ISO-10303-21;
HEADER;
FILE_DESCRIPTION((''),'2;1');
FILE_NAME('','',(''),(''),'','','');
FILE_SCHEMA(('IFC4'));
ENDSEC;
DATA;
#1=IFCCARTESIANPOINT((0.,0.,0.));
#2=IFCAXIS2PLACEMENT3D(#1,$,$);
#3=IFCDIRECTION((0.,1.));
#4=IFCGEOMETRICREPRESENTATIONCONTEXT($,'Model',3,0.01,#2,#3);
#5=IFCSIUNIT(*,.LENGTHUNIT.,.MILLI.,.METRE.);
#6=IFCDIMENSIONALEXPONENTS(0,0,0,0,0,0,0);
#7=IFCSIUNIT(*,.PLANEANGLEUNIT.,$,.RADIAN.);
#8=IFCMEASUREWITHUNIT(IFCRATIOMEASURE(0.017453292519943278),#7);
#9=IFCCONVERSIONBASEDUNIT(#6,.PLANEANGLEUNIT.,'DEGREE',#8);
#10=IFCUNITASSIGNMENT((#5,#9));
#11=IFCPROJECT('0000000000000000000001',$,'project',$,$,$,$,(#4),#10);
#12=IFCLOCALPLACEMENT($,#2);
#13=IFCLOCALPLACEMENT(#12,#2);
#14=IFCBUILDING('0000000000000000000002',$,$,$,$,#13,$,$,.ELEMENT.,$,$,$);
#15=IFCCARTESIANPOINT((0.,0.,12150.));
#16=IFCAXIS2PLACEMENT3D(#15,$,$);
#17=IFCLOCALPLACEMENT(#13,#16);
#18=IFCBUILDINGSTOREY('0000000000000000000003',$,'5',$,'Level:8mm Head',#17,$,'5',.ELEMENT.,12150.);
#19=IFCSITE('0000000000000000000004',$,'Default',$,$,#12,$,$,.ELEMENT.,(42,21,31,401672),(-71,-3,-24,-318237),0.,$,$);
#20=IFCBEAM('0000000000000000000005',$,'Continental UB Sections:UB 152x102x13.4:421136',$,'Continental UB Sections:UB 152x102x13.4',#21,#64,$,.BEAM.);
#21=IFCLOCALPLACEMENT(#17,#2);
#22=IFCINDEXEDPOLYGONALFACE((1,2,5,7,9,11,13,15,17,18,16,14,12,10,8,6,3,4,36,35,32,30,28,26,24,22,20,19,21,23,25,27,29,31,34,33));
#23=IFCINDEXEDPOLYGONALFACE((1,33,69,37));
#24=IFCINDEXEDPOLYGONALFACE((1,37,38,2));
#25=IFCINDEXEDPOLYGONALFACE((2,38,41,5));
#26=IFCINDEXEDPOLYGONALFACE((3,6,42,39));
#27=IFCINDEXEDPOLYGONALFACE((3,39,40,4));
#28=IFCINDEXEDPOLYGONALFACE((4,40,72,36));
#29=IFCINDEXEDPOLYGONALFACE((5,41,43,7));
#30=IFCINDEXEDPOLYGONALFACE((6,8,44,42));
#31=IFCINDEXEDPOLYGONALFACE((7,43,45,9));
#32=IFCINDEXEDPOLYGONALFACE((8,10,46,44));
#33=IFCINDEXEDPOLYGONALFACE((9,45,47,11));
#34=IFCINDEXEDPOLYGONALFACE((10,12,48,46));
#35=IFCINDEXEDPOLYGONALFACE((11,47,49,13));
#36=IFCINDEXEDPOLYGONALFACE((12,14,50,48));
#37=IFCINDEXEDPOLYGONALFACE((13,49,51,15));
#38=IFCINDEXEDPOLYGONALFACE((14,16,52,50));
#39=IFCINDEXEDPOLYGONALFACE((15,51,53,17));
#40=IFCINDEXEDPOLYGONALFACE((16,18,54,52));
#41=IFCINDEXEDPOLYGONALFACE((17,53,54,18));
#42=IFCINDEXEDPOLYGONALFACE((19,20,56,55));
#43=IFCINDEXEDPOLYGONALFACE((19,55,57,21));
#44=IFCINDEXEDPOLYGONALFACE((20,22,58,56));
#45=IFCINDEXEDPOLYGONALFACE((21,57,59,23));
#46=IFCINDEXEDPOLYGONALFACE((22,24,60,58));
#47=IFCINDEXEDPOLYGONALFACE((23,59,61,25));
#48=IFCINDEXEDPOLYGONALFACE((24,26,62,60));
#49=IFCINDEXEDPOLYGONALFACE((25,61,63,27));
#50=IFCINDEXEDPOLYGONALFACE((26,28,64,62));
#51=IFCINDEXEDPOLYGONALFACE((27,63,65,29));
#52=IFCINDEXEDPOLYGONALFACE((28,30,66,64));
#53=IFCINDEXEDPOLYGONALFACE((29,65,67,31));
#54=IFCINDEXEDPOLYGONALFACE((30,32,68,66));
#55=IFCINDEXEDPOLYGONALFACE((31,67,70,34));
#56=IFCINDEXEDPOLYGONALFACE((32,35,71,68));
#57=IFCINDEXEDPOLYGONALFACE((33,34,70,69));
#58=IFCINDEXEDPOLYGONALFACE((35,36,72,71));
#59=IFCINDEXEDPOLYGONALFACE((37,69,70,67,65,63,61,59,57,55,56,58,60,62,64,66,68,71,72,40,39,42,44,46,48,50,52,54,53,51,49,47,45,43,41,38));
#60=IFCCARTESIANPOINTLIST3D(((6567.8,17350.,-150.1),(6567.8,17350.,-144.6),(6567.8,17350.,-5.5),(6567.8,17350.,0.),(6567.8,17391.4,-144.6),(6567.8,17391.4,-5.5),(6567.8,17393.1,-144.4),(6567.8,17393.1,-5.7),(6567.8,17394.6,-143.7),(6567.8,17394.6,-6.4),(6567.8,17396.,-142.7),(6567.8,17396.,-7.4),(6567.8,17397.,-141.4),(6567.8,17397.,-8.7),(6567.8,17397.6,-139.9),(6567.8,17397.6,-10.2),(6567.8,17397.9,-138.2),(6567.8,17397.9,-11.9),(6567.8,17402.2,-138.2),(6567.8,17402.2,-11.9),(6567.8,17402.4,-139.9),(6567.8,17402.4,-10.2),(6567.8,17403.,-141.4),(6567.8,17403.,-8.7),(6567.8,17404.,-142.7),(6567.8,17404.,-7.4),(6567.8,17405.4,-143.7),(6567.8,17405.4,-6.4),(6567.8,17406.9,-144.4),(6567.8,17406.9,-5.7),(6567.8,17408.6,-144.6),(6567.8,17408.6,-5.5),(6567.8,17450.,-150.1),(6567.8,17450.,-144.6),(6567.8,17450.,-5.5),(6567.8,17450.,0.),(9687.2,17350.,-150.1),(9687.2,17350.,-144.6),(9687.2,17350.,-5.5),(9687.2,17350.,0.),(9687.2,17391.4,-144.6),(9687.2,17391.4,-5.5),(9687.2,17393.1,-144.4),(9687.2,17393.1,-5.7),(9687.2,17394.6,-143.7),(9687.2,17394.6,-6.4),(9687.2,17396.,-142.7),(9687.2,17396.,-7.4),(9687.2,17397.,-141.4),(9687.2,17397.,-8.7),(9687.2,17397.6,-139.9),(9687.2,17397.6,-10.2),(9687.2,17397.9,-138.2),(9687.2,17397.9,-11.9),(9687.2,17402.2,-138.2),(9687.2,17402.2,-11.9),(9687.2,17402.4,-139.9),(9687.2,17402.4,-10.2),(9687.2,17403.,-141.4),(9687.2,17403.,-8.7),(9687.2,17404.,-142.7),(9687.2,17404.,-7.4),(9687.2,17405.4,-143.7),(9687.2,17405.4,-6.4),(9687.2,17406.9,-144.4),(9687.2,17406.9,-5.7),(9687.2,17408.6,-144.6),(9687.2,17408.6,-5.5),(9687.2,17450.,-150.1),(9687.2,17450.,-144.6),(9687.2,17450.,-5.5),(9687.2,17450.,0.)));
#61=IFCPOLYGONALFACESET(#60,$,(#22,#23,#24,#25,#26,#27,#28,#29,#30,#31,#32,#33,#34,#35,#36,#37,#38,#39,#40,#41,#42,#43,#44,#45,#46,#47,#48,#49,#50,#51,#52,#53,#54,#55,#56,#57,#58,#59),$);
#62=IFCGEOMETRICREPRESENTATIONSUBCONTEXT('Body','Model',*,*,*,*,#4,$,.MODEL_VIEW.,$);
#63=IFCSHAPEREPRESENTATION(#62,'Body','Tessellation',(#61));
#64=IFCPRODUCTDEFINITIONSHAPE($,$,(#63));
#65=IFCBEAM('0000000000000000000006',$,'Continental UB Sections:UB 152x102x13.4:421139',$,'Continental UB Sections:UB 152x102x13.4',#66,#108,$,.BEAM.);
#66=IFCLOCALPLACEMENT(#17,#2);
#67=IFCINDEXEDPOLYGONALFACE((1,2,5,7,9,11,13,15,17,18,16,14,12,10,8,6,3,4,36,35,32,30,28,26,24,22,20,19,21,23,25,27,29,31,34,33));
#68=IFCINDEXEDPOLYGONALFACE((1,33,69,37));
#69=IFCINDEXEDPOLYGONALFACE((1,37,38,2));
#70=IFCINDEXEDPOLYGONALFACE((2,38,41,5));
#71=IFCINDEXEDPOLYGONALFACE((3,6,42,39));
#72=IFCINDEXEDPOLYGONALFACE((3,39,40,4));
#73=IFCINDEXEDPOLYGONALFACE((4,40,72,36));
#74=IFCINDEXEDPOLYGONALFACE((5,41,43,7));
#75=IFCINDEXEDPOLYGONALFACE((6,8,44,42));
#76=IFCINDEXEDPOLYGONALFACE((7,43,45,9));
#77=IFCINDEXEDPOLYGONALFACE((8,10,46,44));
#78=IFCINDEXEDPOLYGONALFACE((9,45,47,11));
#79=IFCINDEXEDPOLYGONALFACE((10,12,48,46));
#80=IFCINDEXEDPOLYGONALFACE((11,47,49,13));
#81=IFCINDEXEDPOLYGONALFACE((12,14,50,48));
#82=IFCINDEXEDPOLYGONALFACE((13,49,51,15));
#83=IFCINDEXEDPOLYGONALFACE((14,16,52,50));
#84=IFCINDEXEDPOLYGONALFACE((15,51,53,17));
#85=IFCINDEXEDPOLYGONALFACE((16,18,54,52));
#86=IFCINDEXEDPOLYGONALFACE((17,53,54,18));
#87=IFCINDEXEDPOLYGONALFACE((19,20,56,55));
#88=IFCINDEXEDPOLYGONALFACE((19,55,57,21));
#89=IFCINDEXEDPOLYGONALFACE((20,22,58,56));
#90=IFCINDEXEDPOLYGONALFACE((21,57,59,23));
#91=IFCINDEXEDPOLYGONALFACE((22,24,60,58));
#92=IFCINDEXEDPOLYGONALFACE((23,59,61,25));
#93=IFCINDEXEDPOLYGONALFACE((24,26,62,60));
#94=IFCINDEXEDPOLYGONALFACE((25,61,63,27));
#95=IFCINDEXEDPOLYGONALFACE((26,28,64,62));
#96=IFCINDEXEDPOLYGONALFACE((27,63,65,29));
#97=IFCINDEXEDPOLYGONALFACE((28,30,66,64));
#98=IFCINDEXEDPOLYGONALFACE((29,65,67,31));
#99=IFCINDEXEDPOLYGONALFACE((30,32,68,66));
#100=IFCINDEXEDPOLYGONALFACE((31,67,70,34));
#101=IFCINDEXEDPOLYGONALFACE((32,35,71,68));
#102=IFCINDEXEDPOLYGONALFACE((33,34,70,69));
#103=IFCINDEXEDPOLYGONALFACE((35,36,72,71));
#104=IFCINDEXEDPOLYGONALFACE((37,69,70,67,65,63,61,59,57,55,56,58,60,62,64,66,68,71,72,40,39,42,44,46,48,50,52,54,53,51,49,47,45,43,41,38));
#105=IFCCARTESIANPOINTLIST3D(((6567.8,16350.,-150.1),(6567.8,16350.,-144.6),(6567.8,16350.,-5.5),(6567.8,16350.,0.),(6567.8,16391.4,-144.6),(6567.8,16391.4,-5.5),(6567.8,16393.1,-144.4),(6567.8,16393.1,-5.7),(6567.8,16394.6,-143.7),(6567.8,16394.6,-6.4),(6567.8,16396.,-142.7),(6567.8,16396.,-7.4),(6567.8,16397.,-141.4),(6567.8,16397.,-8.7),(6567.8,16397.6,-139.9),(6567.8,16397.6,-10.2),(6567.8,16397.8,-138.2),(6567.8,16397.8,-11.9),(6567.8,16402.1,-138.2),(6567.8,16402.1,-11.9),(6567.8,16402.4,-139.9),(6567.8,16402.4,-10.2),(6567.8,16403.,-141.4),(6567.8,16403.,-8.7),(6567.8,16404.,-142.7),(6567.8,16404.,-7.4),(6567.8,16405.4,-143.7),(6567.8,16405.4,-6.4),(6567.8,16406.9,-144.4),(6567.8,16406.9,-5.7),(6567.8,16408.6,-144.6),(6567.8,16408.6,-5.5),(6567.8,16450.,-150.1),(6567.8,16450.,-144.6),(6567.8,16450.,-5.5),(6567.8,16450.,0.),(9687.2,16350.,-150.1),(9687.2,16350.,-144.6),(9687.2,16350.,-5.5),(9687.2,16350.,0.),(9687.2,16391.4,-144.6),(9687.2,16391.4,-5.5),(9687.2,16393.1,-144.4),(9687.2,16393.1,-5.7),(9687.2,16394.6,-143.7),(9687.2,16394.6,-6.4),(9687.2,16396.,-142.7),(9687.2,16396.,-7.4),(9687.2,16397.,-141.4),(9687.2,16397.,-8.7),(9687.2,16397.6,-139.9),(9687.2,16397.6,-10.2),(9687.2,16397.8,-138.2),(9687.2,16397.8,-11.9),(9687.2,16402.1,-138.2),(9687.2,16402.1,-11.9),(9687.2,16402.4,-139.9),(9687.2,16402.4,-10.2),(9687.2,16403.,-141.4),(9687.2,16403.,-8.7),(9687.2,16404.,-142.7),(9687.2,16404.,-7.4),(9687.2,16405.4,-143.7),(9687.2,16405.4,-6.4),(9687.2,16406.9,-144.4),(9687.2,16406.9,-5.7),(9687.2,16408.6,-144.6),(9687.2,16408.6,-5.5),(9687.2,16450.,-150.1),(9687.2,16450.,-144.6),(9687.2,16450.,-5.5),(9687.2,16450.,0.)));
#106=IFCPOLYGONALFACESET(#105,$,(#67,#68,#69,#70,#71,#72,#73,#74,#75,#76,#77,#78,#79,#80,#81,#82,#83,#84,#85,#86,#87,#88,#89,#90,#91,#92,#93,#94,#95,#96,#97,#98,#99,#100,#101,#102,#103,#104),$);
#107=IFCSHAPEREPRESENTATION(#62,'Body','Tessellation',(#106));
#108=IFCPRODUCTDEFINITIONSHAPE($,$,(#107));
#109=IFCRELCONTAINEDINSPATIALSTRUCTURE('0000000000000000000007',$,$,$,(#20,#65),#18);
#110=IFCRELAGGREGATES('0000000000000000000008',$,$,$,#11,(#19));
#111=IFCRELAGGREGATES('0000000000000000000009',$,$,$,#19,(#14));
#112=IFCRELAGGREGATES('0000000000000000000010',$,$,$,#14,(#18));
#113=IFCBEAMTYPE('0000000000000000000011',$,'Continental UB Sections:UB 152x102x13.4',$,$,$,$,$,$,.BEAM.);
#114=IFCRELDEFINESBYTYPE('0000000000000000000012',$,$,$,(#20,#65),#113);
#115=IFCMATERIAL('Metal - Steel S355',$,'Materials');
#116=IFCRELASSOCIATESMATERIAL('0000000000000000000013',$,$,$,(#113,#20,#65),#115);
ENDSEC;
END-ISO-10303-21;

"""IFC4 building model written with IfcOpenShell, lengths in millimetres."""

from ifc_helpers import new_model, entity, si_unit, converted_unit, direction, frame, origin, place, context, subcontext, project, spatial, line, arc, indexed_curve, outline, extrude, source, transform, mapped, material, type_object, type_shapes, element, save


model = new_model("IFC4")

# Units and contexts
model_context = context("Model", 3, precision=0.01, world=origin(), true_north=direction((0.0, 1.0)))
body_context = subcontext(model_context, "Body", "Model", "MODEL_VIEW")
ifc_project = project(units=[si_unit("LENGTHUNIT", "METRE", prefix="MILLI"), converted_unit("PLANEANGLEUNIT", "DEGREE", entity("IfcRatioMeasure", 0.017453292519943278), si_unit("PLANEANGLEUNIT", "RADIAN"), dimensions=[0, 0, 0, 0, 0, 0, 0])], contexts=[model_context])

# Site, building, storey
site_placement = place(None, origin())
site = spatial("IfcSite", under=ifc_project, at=site_placement, Name="Default", CompositionType="ELEMENT", RefLatitude=(42, 21, 31, 401672), RefLongitude=(-71, -3, -24, -318237), RefElevation=0.0)
building_placement = place(site_placement, origin())
building = spatial("IfcBuilding", under=site, at=building_placement, CompositionType="ELEMENT")
storey_placement = place(building_placement, frame((0.0, 0.0, 12150.0)))
storey = spatial("IfcBuildingStorey", under=building, at=storey_placement, Name="5", ObjectType="Level:8mm Head", LongName="5", CompositionType="ELEMENT", Elevation=12150.0)

# Beams
ifc_material = material(Name="Metal - Steel S355", Category="Materials")
beam_type_1 = type_object("IfcBeamType", Name="Continental UB Sections:UB 152x102x13.4", PredefinedType="BEAM", material=ifc_material)
shared_shape_1 = source(origin(), body_context, "Body", "SweptSolid", [
    extrude(outline(indexed_curve([(-75.0, -50.1), (-69.6, -50.1), (-69.6, -8.5), (-67.7, -4.0), (-63.2, -2.1), (63.1, -2.1), (67.7, -4.0), (69.5, -8.5), (69.5, -50.1), (75.1, -50.1), (75.1, 50.1), (69.5, 50.1), (69.5, 8.6), (67.7, 4.0), (63.1, 2.2), (-63.2, 2.2), (-67.7, 4.0), (-69.6, 8.6), (-69.6, 50.0), (-75.0, 50.0)], segments=[line(1, 2, 3), arc(3, 4, 5), line(5, 6), arc(6, 7, 8), line(8, 9, 10, 11, 12, 13), arc(13, 14, 15), line(15, 16), arc(16, 17, 18), line(18, 19, 20, 1)], self_intersect=False)), frame((-1559.7, 0.0, 0.0), z_axis=(1.0, 0.0, 0.0), x_axis=(0.0, 0.0, -1.0)), (0.0, 0.0, 1.0), 3119.4),
])
type_shapes(beam_type_1, [shared_shape_1])
for number, where, name in (
    (1, (8127.5, 17400.0, -75.1), "Continental UB Sections:UB 152x102x13.4:421136"),
    (2, (8127.5, 16400.0, -75.1), "Continental UB Sections:UB 152x102x13.4:421139"),
):
    element("IfcBeam", number, at=place(storey_placement, frame(where)), inside=storey, type_object=beam_type_1, material=ifc_material, Name=name, ObjectType="Continental UB Sections:UB 152x102x13.4", PredefinedType="BEAM", context=body_context, shape_type="MappedRepresentation", body=[
        mapped(shared_shape_1, transform((0.0, 0.0, 0.0), scale=1.0)),
    ])

save(model, "model.ifc")
